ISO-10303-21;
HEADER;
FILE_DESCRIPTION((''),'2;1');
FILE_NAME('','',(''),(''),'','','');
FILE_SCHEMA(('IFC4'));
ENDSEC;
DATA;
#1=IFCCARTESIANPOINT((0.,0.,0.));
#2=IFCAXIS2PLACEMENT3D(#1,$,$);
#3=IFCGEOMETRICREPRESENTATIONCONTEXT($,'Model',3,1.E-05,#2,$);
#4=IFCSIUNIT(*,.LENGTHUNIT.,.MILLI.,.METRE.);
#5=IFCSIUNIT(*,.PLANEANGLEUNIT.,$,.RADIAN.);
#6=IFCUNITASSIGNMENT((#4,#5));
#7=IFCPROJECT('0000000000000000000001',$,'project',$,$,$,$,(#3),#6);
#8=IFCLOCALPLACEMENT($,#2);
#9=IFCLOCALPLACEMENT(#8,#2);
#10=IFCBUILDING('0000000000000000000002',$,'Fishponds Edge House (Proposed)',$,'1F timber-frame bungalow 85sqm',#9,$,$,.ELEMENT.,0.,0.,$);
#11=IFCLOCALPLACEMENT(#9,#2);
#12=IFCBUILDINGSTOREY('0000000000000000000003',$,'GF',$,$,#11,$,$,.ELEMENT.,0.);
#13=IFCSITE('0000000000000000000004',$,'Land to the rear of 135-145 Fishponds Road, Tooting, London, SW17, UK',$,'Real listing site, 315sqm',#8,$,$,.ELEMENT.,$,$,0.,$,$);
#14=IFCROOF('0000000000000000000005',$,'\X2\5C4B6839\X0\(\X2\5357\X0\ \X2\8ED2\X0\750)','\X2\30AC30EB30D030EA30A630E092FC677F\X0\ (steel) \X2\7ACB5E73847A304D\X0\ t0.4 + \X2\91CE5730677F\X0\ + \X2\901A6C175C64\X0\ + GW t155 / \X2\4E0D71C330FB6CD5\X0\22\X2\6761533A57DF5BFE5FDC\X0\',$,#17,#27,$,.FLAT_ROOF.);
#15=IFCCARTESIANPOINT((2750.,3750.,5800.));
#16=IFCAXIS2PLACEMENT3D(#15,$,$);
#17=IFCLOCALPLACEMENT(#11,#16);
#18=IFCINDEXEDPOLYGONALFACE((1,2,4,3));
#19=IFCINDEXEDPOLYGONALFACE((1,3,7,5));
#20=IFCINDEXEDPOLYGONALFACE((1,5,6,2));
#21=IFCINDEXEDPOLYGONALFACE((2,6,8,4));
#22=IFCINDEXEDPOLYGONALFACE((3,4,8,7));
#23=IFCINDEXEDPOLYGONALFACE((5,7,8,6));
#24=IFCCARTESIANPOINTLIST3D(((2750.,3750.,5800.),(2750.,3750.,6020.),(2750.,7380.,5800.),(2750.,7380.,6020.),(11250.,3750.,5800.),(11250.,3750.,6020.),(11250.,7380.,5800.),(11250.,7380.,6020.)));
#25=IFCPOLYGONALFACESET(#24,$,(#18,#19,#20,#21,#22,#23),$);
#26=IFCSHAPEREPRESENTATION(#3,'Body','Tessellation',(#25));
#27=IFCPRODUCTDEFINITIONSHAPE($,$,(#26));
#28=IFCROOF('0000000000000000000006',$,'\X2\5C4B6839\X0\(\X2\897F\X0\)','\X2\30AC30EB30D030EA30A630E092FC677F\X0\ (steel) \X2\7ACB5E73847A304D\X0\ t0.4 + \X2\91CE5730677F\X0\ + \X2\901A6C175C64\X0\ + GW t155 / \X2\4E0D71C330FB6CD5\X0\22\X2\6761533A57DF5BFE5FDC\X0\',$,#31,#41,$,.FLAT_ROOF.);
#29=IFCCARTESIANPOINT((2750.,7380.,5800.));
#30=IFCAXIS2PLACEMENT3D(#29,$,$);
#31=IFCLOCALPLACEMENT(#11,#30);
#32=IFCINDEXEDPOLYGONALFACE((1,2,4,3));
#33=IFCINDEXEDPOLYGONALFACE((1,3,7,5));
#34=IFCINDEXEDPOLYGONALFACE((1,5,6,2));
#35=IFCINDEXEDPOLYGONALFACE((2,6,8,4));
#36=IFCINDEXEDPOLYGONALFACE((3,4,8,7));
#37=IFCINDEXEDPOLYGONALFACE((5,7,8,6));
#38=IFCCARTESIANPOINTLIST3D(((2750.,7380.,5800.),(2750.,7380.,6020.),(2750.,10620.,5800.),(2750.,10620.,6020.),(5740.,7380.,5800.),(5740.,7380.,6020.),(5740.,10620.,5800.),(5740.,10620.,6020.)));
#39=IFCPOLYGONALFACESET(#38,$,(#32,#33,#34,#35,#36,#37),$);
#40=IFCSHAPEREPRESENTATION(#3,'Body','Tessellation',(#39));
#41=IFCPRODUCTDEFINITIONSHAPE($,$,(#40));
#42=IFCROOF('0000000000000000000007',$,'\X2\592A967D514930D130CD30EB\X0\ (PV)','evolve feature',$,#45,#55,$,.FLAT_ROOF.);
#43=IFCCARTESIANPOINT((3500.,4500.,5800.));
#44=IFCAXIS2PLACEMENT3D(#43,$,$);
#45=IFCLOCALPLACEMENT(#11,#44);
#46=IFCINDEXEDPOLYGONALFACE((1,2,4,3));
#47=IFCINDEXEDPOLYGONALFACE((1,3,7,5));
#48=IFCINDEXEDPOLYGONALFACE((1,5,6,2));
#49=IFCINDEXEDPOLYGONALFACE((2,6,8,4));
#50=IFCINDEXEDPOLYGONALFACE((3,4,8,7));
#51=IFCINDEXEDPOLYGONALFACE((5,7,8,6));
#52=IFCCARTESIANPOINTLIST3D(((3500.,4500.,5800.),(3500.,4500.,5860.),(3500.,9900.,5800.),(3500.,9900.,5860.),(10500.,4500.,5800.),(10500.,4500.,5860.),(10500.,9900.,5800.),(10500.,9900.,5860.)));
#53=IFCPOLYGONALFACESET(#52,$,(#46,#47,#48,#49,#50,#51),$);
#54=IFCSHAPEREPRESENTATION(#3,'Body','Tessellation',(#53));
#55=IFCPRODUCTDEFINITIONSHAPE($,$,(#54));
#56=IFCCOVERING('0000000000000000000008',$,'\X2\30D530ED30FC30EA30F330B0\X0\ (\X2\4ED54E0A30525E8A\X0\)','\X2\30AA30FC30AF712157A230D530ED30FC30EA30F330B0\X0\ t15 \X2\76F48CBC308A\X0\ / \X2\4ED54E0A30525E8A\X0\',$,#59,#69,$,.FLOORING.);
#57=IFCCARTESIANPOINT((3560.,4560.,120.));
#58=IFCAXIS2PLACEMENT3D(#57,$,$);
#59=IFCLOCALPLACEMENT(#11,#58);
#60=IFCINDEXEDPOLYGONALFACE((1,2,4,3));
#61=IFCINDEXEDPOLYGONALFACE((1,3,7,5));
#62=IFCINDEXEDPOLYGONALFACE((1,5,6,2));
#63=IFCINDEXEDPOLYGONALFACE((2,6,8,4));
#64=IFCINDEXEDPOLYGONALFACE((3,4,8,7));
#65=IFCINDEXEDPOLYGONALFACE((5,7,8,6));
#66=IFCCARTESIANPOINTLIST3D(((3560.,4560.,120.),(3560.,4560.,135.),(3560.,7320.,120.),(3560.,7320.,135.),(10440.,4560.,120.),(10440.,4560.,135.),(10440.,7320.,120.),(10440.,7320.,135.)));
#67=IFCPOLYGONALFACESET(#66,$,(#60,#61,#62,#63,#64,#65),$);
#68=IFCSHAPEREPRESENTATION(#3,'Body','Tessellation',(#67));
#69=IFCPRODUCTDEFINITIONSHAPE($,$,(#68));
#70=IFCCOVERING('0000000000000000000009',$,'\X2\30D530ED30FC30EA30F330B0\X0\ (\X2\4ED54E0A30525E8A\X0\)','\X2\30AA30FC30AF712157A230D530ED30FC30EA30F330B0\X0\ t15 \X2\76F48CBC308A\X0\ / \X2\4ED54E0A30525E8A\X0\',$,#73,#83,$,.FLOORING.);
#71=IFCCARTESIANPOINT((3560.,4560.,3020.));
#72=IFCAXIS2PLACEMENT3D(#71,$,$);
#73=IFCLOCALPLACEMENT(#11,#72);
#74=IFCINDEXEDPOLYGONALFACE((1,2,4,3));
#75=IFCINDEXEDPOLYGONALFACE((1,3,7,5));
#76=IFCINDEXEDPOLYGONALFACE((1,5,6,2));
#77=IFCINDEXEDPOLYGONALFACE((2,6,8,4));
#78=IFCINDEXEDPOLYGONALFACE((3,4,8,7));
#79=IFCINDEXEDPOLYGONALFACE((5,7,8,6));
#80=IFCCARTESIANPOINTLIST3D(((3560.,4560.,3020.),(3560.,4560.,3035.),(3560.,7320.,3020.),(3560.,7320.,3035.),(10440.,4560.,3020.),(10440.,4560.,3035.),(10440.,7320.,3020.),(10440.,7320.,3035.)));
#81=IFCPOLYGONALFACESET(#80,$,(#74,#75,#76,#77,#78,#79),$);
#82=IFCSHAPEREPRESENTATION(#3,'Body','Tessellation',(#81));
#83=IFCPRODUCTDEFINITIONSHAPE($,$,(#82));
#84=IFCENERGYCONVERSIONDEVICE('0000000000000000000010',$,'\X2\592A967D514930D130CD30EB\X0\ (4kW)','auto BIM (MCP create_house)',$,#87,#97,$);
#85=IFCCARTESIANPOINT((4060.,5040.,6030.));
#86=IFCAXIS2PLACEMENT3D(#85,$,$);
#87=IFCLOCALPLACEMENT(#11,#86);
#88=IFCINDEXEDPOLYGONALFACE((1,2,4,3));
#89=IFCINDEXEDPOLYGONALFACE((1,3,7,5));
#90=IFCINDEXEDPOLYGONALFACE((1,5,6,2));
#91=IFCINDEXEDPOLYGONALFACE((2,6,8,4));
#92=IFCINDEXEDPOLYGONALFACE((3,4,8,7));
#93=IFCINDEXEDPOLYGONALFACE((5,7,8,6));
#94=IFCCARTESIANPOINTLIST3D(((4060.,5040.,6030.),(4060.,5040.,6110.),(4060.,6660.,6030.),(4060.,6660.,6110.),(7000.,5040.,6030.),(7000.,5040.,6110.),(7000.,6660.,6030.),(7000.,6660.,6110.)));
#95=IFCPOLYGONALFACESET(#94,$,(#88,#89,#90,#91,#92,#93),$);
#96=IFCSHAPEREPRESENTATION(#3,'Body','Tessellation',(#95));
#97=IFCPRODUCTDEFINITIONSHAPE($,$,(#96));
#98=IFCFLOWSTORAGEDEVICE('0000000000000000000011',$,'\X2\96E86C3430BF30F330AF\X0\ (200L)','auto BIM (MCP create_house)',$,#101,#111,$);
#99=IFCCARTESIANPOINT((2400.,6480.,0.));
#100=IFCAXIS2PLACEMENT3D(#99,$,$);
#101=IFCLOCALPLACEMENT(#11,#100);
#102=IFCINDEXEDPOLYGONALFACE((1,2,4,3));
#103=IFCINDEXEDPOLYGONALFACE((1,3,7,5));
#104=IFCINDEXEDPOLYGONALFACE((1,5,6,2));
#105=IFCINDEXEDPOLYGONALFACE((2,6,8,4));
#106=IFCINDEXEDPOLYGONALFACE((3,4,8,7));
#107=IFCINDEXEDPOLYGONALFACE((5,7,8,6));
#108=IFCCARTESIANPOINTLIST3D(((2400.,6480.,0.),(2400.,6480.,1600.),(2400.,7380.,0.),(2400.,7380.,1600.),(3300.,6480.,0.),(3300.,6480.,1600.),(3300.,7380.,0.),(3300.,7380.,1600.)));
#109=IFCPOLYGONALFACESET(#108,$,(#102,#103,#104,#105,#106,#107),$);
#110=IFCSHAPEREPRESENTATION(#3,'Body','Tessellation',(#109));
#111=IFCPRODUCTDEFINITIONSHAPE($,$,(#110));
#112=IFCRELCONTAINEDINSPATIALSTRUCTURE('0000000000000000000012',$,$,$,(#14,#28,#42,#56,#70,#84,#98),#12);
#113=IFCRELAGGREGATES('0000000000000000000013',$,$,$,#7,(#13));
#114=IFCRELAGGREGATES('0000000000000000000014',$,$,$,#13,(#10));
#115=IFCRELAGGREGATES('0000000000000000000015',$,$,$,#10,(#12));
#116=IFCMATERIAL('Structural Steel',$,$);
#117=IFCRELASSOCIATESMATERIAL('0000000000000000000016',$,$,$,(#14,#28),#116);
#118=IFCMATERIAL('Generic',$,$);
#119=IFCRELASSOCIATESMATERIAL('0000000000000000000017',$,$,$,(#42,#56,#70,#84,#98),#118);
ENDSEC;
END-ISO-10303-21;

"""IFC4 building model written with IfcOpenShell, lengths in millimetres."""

from ifc_helpers import new_model, si_unit, frame, frame_2d, origin, place, context, project, spatial, rectangle, extrude, material, element, save


model = new_model("IFC4")

# Units and contexts
model_context = context("Model", 3, precision=1e-05, world=origin())
ifc_project = project(units=[si_unit("LENGTHUNIT", "METRE", prefix="MILLI"), si_unit("PLANEANGLEUNIT", "RADIAN")], contexts=[model_context])

# Site, building, storey
site_placement = place(None, origin())
site = spatial("IfcSite", under=ifc_project, at=site_placement, Name="Land to the rear of 135-145 Fishponds Road, Tooting, London, SW17, UK", ObjectType="Real listing site, 315sqm", CompositionType="ELEMENT", RefElevation=0.0)
building_placement = place(site_placement, origin())
building = spatial("IfcBuilding", under=site, at=building_placement, Name="Fishponds Edge House (Proposed)", ObjectType="1F timber-frame bungalow 85sqm", CompositionType="ELEMENT", ElevationOfRefHeight=0.0, ElevationOfTerrain=0.0)
storey_placement = place(building_placement, origin())
storey = spatial("IfcBuildingStorey", under=building, at=storey_placement, Name="GF", CompositionType="ELEMENT", Elevation=0.0)

# Shared definitions
ifc_material_1 = material(Name="Generic")

# Roofs
ifc_material_2 = material(Name="Structural Steel")
roof_1_placement = place(storey_placement, frame((2750.0, 3750.0, 5800.0)))
element("IfcRoof", 1, at=roof_1_placement, inside=storey, material=ifc_material_2, Name="屋根(南 軒750)", Description="ガルバリウム鋼板 (steel) 立平葺き t0.4 + 野地板 + 通気層 + GW t155 / 不燃・法22条区域対応", PredefinedType="FLAT_ROOF", context=model_context, shape_type="SweptSolid", body=[
    extrude(rectangle(XDim=8500.0, YDim=3630.0, at=frame_2d((4250.0, 1815.0))), frame((2750.0, 3750.0, 5800.0)), (0.0, 0.0, 1.0), 220.0),
])
roof_2_placement = place(storey_placement, frame((2750.0, 7380.0, 5800.0)))
element("IfcRoof", 2, at=roof_2_placement, inside=storey, material=ifc_material_2, Name="屋根(西)", Description="ガルバリウム鋼板 (steel) 立平葺き t0.4 + 野地板 + 通気層 + GW t155 / 不燃・法22条区域対応", PredefinedType="FLAT_ROOF", context=model_context, shape_type="SweptSolid", body=[
    extrude(rectangle(XDim=2990.0, YDim=3240.0, at=frame_2d((1495.0, 1620.0))), frame((2750.0, 7380.0, 5800.0)), (0.0, 0.0, 1.0), 220.0),
])
roof_3_placement = place(storey_placement, frame((3500.0, 4500.0, 5800.0)))
element("IfcRoof", 3, at=roof_3_placement, inside=storey, material=ifc_material_1, Name="太陽光パネル (PV)", Description="evolve feature", PredefinedType="FLAT_ROOF", context=model_context, shape_type="SweptSolid", body=[
    extrude(rectangle(XDim=7000.0, YDim=5400.0, at=frame_2d((3500.0, 2700.0))), frame((3500.0, 4500.0, 5800.0)), (0.0, 0.0, 1.0), 60.0),
])

# Coverings
covering_1_placement = place(storey_placement, frame((3560.0, 4560.0, 120.0)))
element("IfcCovering", 4, at=covering_1_placement, inside=storey, material=ifc_material_1, Name="フローリング (仕上げ床)", Description="オーク無垢フローリング t15 直貼り / 仕上げ床", PredefinedType="FLOORING", context=model_context, shape_type="SweptSolid", body=[
    extrude(rectangle(XDim=6880.0, YDim=2760.0, at=frame_2d((3440.0, 1380.0))), frame((3560.0, 4560.0, 120.0)), (0.0, 0.0, 1.0), 15.0),
])
covering_2_placement = place(storey_placement, frame((3560.0, 4560.0, 3020.0)))
element("IfcCovering", 5, at=covering_2_placement, inside=storey, material=ifc_material_1, Name="フローリング (仕上げ床)", Description="オーク無垢フローリング t15 直貼り / 仕上げ床", PredefinedType="FLOORING", context=model_context, shape_type="SweptSolid", body=[
    extrude(rectangle(XDim=6880.0, YDim=2760.0, at=frame_2d((3440.0, 1380.0))), frame((3560.0, 4560.0, 3020.0)), (0.0, 0.0, 1.0), 15.0),
])

# Energy conversion device
energy_conversion_device_placement = place(storey_placement, frame((4060.0, 5040.0, 6030.0)))
element("IfcEnergyConversionDevice", 6, at=energy_conversion_device_placement, inside=storey, material=ifc_material_1, Name="太陽光パネル (4kW)", Description="auto BIM (MCP create_house)", context=model_context, shape_type="SweptSolid", body=[
    extrude(rectangle(XDim=2940.0, YDim=1620.0, at=frame_2d((1470.0, 810.0))), frame((4060.0, 5040.0, 6030.0)), (0.0, 0.0, 1.0), 80.0),
])

# Flow storage device
flow_storage_device_placement = place(storey_placement, frame((2400.0, 6480.0, 0.0)))
element("IfcFlowStorageDevice", 7, at=flow_storage_device_placement, inside=storey, material=ifc_material_1, Name="雨水タンク (200L)", Description="auto BIM (MCP create_house)", context=model_context, shape_type="SweptSolid", body=[
    extrude(rectangle(XDim=900.0, YDim=900.0, at=frame_2d((450.0, 450.0))), frame((2400.0, 6480.0, 0.0)), (0.0, 0.0, 1.0), 1600.0),
])

save(model, "model.ifc")
